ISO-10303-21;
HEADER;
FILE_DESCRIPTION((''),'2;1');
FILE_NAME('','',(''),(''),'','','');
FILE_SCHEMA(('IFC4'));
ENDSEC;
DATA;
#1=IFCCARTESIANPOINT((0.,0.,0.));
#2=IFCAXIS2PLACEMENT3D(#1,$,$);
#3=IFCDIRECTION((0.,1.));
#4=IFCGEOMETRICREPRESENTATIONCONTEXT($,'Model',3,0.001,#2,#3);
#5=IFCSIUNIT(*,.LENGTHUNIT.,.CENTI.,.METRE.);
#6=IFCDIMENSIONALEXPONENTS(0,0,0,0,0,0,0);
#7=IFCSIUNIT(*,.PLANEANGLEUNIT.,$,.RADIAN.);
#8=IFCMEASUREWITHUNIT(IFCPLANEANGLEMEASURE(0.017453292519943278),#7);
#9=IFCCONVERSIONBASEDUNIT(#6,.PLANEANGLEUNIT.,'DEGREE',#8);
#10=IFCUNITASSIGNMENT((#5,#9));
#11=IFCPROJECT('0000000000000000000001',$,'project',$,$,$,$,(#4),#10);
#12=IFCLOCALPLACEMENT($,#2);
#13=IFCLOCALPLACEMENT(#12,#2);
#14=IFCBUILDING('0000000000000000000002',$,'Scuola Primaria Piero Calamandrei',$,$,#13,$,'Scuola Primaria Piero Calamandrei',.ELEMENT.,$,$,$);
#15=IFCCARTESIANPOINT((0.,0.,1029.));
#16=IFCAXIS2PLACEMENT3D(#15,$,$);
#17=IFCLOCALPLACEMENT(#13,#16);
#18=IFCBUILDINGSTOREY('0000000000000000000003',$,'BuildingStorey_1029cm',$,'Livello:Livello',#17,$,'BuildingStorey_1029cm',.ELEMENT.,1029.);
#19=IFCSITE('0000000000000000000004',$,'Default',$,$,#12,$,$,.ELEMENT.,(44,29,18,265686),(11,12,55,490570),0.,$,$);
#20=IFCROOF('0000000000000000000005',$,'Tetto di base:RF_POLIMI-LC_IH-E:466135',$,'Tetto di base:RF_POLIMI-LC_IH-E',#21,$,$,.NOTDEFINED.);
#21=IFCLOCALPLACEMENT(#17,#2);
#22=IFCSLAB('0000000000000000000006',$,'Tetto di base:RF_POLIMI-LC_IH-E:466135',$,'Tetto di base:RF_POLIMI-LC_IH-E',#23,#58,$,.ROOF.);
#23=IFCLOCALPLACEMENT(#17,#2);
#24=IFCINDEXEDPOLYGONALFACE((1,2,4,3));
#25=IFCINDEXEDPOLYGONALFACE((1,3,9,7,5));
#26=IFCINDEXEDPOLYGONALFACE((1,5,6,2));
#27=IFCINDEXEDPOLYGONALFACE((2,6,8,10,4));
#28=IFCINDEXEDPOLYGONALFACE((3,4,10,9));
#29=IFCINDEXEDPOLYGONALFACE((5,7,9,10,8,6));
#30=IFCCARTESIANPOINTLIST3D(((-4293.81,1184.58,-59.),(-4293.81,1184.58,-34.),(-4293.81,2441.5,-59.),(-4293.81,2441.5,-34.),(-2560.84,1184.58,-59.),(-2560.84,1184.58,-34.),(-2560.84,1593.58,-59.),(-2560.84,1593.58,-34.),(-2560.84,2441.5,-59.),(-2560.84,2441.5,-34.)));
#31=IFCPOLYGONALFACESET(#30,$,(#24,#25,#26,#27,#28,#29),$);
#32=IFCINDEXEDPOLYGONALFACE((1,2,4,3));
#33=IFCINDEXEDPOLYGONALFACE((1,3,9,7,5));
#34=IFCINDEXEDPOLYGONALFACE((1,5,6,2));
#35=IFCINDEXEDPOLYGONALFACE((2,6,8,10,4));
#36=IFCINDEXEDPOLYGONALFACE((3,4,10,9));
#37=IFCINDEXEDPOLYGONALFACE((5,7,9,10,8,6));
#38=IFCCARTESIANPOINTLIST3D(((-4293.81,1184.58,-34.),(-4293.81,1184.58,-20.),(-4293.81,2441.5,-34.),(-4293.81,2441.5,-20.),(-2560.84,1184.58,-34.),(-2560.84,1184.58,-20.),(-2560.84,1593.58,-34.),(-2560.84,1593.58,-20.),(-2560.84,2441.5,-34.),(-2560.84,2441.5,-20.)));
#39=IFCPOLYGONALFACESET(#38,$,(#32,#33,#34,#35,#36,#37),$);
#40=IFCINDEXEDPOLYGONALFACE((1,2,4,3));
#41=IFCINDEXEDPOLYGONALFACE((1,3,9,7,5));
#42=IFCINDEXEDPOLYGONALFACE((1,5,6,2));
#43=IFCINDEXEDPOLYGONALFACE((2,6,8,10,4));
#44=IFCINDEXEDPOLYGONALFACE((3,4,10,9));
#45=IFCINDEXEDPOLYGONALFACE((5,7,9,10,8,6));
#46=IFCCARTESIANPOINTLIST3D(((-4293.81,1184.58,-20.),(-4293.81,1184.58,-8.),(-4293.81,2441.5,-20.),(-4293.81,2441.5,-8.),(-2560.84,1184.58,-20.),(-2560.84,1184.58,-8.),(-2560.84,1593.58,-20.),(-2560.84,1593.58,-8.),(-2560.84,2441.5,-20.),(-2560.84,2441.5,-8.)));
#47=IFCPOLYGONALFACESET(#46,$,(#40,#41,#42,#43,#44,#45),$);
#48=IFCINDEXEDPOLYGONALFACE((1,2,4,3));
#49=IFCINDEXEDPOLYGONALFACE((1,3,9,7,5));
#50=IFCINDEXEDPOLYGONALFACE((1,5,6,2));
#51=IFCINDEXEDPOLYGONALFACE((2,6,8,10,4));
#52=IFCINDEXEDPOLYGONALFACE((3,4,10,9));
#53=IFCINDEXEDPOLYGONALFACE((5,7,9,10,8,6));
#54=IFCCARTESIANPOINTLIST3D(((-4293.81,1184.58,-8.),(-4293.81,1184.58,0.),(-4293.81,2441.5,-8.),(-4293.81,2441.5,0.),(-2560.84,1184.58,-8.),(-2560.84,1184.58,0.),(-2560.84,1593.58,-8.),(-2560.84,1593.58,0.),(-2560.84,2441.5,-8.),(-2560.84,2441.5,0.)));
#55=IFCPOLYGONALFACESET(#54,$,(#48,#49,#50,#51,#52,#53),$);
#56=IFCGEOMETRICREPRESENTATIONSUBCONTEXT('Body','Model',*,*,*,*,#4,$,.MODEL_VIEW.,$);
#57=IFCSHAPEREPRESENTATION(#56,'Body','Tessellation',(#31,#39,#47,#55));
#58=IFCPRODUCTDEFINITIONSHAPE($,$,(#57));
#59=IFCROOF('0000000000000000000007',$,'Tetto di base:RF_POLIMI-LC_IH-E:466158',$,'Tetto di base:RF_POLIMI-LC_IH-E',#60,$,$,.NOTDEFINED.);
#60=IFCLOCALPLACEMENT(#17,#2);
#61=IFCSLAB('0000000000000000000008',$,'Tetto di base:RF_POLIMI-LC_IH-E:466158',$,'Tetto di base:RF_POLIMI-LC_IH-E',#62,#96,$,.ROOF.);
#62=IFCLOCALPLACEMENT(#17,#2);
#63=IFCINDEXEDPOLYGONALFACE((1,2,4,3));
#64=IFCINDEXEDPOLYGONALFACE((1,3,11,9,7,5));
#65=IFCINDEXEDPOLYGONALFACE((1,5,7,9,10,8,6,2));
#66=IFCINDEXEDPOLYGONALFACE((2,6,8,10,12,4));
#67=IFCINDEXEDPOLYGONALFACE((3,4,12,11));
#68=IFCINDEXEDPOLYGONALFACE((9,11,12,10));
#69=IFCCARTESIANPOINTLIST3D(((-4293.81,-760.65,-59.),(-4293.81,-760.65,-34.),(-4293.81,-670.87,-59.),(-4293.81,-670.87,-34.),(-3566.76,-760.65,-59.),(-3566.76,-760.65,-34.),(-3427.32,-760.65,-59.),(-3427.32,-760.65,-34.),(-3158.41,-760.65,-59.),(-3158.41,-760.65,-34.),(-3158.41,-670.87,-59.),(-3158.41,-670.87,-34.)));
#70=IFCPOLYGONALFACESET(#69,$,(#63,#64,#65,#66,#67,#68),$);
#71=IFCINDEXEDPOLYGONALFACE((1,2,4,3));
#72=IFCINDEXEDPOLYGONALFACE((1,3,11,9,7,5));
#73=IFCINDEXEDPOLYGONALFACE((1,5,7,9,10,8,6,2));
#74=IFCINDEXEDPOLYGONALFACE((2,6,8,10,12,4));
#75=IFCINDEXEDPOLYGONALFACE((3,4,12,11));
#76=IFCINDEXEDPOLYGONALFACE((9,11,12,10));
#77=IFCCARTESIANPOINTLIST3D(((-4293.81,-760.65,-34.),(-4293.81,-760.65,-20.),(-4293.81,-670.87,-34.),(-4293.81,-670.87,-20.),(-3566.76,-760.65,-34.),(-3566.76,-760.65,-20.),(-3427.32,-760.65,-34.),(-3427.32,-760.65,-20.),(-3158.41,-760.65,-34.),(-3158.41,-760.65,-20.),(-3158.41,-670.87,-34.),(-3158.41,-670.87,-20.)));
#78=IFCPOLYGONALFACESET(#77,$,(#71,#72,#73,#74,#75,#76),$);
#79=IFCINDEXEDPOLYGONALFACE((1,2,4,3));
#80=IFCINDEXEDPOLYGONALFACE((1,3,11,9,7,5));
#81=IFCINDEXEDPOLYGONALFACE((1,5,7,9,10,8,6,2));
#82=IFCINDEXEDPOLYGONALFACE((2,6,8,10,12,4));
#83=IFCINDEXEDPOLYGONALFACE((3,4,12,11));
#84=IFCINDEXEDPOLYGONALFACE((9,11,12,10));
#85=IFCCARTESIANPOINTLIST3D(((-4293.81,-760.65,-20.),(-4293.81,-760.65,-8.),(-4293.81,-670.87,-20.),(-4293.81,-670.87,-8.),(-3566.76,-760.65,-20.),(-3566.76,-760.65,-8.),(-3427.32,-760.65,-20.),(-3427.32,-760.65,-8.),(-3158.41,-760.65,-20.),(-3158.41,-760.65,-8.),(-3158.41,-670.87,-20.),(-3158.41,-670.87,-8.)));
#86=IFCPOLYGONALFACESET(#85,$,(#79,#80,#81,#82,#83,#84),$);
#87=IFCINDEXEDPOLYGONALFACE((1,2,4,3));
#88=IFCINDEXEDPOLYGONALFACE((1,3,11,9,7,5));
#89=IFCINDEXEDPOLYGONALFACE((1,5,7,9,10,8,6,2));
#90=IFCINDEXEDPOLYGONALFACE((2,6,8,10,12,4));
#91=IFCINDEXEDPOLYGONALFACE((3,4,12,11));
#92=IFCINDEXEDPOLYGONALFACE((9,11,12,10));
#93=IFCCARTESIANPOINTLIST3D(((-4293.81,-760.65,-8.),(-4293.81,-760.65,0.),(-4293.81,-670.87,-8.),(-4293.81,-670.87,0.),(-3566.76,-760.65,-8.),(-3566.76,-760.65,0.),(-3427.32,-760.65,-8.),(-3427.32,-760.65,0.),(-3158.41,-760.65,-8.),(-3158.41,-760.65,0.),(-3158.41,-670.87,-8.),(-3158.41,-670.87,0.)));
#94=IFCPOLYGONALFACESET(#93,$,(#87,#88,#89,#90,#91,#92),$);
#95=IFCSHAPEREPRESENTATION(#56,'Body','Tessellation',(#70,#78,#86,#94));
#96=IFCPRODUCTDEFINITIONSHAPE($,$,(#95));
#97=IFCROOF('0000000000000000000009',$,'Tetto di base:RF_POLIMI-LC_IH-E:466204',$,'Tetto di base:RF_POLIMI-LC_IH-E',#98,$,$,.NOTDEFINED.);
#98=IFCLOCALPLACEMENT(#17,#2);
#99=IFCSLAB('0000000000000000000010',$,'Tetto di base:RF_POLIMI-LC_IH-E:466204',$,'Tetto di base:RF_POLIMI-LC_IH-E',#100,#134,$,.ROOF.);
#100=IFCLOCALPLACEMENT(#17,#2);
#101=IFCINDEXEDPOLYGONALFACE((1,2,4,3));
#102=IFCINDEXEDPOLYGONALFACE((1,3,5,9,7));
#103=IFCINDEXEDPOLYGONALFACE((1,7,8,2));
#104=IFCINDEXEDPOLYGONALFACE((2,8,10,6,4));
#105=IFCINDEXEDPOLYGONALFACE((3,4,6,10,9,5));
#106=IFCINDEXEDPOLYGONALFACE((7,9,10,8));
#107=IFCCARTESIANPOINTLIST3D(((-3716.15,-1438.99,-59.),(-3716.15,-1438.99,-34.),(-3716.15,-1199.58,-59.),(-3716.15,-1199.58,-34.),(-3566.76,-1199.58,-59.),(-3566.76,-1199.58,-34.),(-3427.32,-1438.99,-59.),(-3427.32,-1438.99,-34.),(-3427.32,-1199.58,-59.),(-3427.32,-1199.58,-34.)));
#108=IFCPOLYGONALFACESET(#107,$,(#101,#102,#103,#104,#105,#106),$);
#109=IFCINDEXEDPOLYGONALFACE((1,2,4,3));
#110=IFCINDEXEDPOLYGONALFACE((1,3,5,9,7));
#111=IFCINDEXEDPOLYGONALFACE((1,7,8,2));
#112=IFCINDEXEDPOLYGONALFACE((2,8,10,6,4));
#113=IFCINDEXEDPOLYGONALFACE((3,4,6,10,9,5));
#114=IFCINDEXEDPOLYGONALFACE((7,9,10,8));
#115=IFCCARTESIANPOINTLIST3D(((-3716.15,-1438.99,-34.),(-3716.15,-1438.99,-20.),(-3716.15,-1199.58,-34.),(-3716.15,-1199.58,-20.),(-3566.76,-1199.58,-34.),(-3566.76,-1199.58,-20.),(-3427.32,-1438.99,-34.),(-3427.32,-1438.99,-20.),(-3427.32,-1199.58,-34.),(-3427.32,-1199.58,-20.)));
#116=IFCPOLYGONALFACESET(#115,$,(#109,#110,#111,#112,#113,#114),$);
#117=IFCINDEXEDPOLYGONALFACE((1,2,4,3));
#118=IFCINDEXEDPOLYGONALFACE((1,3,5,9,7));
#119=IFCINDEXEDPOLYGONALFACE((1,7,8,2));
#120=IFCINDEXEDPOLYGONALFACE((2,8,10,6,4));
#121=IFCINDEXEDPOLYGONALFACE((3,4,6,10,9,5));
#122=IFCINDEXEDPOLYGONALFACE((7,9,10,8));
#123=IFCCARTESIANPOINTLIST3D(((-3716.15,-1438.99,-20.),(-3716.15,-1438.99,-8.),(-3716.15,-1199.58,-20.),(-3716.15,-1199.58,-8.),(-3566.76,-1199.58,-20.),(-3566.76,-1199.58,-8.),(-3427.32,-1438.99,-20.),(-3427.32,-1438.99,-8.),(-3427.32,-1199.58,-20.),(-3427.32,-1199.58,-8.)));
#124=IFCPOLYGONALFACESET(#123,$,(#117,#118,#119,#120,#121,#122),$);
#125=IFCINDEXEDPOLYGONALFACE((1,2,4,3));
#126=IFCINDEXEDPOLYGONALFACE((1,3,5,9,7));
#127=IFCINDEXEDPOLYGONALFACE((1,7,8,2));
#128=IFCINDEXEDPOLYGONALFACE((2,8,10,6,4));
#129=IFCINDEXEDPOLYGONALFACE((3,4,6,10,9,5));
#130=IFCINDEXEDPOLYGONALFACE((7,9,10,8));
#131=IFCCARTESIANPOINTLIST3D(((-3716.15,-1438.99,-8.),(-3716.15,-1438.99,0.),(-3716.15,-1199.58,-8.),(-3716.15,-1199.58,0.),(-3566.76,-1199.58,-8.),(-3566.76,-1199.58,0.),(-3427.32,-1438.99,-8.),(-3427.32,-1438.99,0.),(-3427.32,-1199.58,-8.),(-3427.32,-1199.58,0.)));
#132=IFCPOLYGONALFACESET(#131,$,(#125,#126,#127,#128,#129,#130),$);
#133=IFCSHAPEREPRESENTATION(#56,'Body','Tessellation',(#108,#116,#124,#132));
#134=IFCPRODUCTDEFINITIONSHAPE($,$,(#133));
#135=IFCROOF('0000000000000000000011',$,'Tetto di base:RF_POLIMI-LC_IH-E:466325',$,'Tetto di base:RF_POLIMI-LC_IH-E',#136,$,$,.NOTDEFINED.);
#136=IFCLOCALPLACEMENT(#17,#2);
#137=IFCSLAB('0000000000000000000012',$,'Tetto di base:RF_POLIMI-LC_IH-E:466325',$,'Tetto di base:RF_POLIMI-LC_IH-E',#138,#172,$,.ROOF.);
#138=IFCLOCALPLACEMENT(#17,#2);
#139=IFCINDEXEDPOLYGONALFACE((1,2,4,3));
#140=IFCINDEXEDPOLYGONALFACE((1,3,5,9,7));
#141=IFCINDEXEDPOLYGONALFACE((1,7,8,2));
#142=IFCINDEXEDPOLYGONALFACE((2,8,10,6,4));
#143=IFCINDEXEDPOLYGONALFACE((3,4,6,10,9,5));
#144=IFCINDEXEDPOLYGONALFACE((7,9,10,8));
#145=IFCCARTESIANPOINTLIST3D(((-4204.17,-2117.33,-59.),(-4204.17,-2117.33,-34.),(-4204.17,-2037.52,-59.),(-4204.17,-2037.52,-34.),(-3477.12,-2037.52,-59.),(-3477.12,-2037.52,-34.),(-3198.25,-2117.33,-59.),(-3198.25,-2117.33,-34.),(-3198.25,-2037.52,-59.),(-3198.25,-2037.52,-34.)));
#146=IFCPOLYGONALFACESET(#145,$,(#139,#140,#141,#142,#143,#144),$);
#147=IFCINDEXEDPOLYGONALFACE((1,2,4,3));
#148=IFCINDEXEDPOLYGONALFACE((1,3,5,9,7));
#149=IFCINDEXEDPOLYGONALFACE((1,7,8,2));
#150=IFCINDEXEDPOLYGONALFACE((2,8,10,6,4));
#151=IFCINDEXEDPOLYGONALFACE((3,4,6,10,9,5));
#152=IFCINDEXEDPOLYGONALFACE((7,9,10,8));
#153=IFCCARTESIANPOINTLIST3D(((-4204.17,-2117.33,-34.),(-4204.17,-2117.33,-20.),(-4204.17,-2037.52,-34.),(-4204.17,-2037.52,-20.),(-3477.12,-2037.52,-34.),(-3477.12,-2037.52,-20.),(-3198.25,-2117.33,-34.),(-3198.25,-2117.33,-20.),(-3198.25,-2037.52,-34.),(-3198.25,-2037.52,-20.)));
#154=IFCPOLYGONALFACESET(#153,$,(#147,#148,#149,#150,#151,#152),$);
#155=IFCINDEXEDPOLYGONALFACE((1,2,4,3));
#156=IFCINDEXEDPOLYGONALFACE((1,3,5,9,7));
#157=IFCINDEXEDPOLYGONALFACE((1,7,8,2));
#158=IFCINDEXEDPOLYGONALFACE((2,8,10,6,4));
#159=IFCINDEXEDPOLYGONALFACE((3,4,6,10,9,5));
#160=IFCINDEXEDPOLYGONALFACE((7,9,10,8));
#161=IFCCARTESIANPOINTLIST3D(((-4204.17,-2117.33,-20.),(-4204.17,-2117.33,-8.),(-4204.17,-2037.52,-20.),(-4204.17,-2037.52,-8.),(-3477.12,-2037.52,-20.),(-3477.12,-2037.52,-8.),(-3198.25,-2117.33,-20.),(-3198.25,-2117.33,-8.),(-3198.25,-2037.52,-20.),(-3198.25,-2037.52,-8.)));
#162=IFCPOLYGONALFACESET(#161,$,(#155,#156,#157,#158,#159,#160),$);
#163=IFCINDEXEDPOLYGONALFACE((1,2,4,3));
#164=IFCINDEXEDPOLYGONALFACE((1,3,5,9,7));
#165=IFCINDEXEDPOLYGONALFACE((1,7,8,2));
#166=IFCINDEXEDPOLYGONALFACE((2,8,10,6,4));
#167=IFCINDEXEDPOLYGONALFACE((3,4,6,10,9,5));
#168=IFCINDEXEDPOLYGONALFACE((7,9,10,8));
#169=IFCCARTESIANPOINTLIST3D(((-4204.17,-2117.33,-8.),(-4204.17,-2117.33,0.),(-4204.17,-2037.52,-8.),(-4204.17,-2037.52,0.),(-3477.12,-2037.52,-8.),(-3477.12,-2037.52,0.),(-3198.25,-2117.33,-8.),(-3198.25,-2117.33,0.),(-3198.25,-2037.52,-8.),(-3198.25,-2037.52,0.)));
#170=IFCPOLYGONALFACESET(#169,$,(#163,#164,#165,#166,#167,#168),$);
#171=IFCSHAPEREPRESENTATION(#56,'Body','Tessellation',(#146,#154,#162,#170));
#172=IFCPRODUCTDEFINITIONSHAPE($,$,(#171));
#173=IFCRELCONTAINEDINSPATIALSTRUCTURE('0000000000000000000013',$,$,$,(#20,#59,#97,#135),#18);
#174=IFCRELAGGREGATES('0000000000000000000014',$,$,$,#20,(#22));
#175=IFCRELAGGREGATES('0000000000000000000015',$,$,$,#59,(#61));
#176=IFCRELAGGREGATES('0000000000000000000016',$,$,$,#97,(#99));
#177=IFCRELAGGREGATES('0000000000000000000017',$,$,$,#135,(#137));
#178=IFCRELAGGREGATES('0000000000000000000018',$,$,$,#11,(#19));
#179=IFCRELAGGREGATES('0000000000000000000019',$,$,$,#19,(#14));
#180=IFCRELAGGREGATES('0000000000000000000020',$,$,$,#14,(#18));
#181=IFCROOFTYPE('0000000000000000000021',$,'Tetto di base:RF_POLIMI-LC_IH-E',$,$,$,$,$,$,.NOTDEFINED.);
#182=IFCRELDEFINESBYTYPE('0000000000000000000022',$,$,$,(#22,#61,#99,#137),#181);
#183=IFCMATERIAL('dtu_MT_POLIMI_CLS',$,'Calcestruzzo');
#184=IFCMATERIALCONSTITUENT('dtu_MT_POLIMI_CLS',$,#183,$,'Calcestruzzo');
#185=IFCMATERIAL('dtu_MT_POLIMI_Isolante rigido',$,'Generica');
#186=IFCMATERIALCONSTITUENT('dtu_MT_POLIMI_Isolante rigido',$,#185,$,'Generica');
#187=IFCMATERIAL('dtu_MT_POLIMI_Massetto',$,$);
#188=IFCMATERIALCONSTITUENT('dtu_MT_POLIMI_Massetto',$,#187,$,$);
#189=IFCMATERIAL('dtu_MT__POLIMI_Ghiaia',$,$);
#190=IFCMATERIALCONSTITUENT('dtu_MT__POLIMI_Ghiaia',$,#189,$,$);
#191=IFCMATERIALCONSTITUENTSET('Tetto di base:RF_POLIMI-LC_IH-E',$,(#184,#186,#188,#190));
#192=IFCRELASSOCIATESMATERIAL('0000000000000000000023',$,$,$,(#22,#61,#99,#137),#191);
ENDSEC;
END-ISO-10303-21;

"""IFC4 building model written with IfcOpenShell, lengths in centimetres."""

from ifc_helpers import new_model, entity, si_unit, converted_unit, direction, frame, origin, place, context, subcontext, project, spatial, indexed_curve, outline, extrude, material, constituent, constituent_set, type_object, element, aggregate, save


model = new_model("IFC4")

# Units and contexts
model_context = context("Model", 3, precision=0.001, world=origin(), true_north=direction((0.0, 1.0)))
body_context = subcontext(model_context, "Body", "Model", "MODEL_VIEW")
ifc_project = project(units=[si_unit("LENGTHUNIT", "METRE", prefix="CENTI"), converted_unit("PLANEANGLEUNIT", "DEGREE", entity("IfcPlaneAngleMeasure", 0.017453292519943278), si_unit("PLANEANGLEUNIT", "RADIAN"), dimensions=[0, 0, 0, 0, 0, 0, 0])], contexts=[model_context])

# Site, building, storey
site_placement = place(None, origin())
site = spatial("IfcSite", under=ifc_project, at=site_placement, Name="Default", CompositionType="ELEMENT", RefLatitude=(44, 29, 18, 265686), RefLongitude=(11, 12, 55, 490570), RefElevation=0.0)
building_placement = place(site_placement, origin())
building = spatial("IfcBuilding", under=site, at=building_placement, Name="Scuola Primaria Piero Calamandrei", LongName="Scuola Primaria Piero Calamandrei", CompositionType="ELEMENT")
storey_placement = place(building_placement, frame((0.0, 0.0, 1029.0)))
storey = spatial("IfcBuildingStorey", under=building, at=storey_placement, Name="BuildingStorey_1029cm", ObjectType="Livello:Livello", LongName="BuildingStorey_1029cm", CompositionType="ELEMENT", Elevation=1029.0)

# Shared definitions
ifc_material_1 = material(Name="dtu_MT_POLIMI_Isolante rigido", Category="Generica")

# Roofs, slabs
ifc_material_2 = material(Name="dtu_MT_POLIMI_CLS", Category="Calcestruzzo")
ifc_constituent_1 = constituent(ifc_material_2, Name="dtu_MT_POLIMI_CLS", Category="Calcestruzzo")
ifc_constituent_2 = constituent(ifc_material_1, Name="dtu_MT_POLIMI_Isolante rigido", Category="Generica")
ifc_material_3 = material(Name="dtu_MT_POLIMI_Massetto")
ifc_constituent_3 = constituent(ifc_material_3, Name="dtu_MT_POLIMI_Massetto")
ifc_material_4 = material(Name="dtu_MT__POLIMI_Ghiaia")
ifc_constituent_4 = constituent(ifc_material_4, Name="dtu_MT__POLIMI_Ghiaia")
ifc_constituent_set_1 = constituent_set(constituents=[ifc_constituent_1, ifc_constituent_2, ifc_constituent_3, ifc_constituent_4], Name="Tetto di base:RF_POLIMI-LC_IH-E")
roof_type = type_object("IfcRoofType", Name="Tetto di base:RF_POLIMI-LC_IH-E", PredefinedType="NOTDEFINED")
roof_1_placement = place(storey_placement, frame((-4293.81, 1184.58, -59.0)))
roof_1 = element("IfcRoof", 1, at=roof_1_placement, inside=storey, Name="Tetto di base:RF_POLIMI-LC_IH-E:466135", ObjectType="Tetto di base:RF_POLIMI-LC_IH-E", PredefinedType="NOTDEFINED")
slab_1_placement = place(roof_1_placement, origin())
slab_1 = element("IfcSlab", 2, at=slab_1_placement, type_object=roof_type, material=ifc_constituent_set_1, Name="Tetto di base:RF_POLIMI-LC_IH-E:466135", ObjectType="Tetto di base:RF_POLIMI-LC_IH-E", PredefinedType="ROOF", context=body_context, shape_type="SweptSolid", body=[
    extrude(outline(indexed_curve([(866.49, -628.46), (866.49, -219.46), (866.49, 628.46), (-866.49, 628.46), (-866.49, -628.46), (866.49, -628.46)], self_intersect=False)), frame((866.49, 628.46, 0.0)), (0.0, 0.0, 1.0), 25.0),
    extrude(outline(indexed_curve([(866.49, -628.46), (866.49, -219.46), (866.49, 628.46), (-866.49, 628.46), (-866.49, -628.46), (866.49, -628.46)], self_intersect=False)), frame((866.49, 628.46, 25.0)), (0.0, 0.0, 1.0), 14.0),
    extrude(outline(indexed_curve([(866.49, -628.46), (866.49, -219.46), (866.49, 628.46), (-866.49, 628.46), (-866.49, -628.46), (866.49, -628.46)], self_intersect=False)), frame((866.49, 628.46, 39.0)), (0.0, 0.0, 1.0), 12.0),
    extrude(outline(indexed_curve([(866.49, -628.46), (866.49, -219.46), (866.49, 628.46), (-866.49, 628.46), (-866.49, -628.46), (866.49, -628.46)], self_intersect=False)), frame((866.49, 628.46, 51.0)), (0.0, 0.0, 1.0), 8.0),
])
aggregate(roof_1, [slab_1])
roof_2_placement = place(storey_placement, frame((-4293.81, -760.65, -59.0)))
roof_2 = element("IfcRoof", 3, at=roof_2_placement, inside=storey, Name="Tetto di base:RF_POLIMI-LC_IH-E:466158", ObjectType="Tetto di base:RF_POLIMI-LC_IH-E", PredefinedType="NOTDEFINED")
slab_2_placement = place(roof_2_placement, origin())
slab_2 = element("IfcSlab", 4, at=slab_2_placement, type_object=roof_type, material=ifc_constituent_set_1, Name="Tetto di base:RF_POLIMI-LC_IH-E:466158", ObjectType="Tetto di base:RF_POLIMI-LC_IH-E", PredefinedType="ROOF", context=body_context, shape_type="SweptSolid", body=[
    extrude(outline(indexed_curve([(-567.7, 44.89), (-567.7, -44.89), (159.35, -44.89), (298.79, -44.89), (567.7, -44.89), (567.7, 44.89), (-567.7, 44.89)], self_intersect=False)), frame((567.7, 44.89, 0.0)), (0.0, 0.0, 1.0), 25.0),
    extrude(outline(indexed_curve([(-567.7, 44.89), (-567.7, -44.89), (159.35, -44.89), (298.79, -44.89), (567.7, -44.89), (567.7, 44.89), (-567.7, 44.89)], self_intersect=False)), frame((567.7, 44.89, 25.0)), (0.0, 0.0, 1.0), 14.0),
    extrude(outline(indexed_curve([(-567.7, 44.89), (-567.7, -44.89), (159.35, -44.89), (298.79, -44.89), (567.7, -44.89), (567.7, 44.89), (-567.7, 44.89)], self_intersect=False)), frame((567.7, 44.89, 39.0)), (0.0, 0.0, 1.0), 12.0),
    extrude(outline(indexed_curve([(-567.7, 44.89), (-567.7, -44.89), (159.35, -44.89), (298.79, -44.89), (567.7, -44.89), (567.7, 44.89), (-567.7, 44.89)], self_intersect=False)), frame((567.7, 44.89, 51.0)), (0.0, 0.0, 1.0), 8.0),
])
aggregate(roof_2, [slab_2])
roof_3_placement = place(storey_placement, frame((-3716.15, -1438.99, -59.0)))
roof_3 = element("IfcRoof", 5, at=roof_3_placement, inside=storey, Name="Tetto di base:RF_POLIMI-LC_IH-E:466204", ObjectType="Tetto di base:RF_POLIMI-LC_IH-E", PredefinedType="NOTDEFINED")
slab_3_placement = place(roof_3_placement, origin())
slab_3 = element("IfcSlab", 6, at=slab_3_placement, type_object=roof_type, material=ifc_constituent_set_1, Name="Tetto di base:RF_POLIMI-LC_IH-E:466204", ObjectType="Tetto di base:RF_POLIMI-LC_IH-E", PredefinedType="ROOF", context=body_context, shape_type="SweptSolid", body=[
    extrude(outline(indexed_curve([(-144.41, -119.71), (144.41, -119.71), (144.41, 119.71), (4.98, 119.71), (-144.41, 119.71), (-144.41, -119.71)], self_intersect=False)), frame((144.41, 119.71, 0.0)), (0.0, 0.0, 1.0), 25.0),
    extrude(outline(indexed_curve([(-144.41, -119.71), (144.41, -119.71), (144.41, 119.71), (4.98, 119.71), (-144.41, 119.71), (-144.41, -119.71)], self_intersect=False)), frame((144.41, 119.71, 25.0)), (0.0, 0.0, 1.0), 14.0),
    extrude(outline(indexed_curve([(-144.41, -119.71), (144.41, -119.71), (144.41, 119.71), (4.98, 119.71), (-144.41, 119.71), (-144.41, -119.71)], self_intersect=False)), frame((144.41, 119.71, 39.0)), (0.0, 0.0, 1.0), 12.0),
    extrude(outline(indexed_curve([(-144.41, -119.71), (144.41, -119.71), (144.41, 119.71), (4.98, 119.71), (-144.41, 119.71), (-144.41, -119.71)], self_intersect=False)), frame((144.41, 119.71, 51.0)), (0.0, 0.0, 1.0), 8.0),
])
aggregate(roof_3, [slab_3])
roof_4_placement = place(storey_placement, frame((-4204.17, -2117.33, -59.0)))
roof_4 = element("IfcRoof", 7, at=roof_4_placement, inside=storey, Name="Tetto di base:RF_POLIMI-LC_IH-E:466325", ObjectType="Tetto di base:RF_POLIMI-LC_IH-E", PredefinedType="NOTDEFINED")
slab_4_placement = place(roof_4_placement, origin())
slab_4 = element("IfcSlab", 8, at=slab_4_placement, type_object=roof_type, material=ifc_constituent_set_1, Name="Tetto di base:RF_POLIMI-LC_IH-E:466325", ObjectType="Tetto di base:RF_POLIMI-LC_IH-E", PredefinedType="ROOF", context=body_context, shape_type="SweptSolid", body=[
    extrude(outline(indexed_curve([(224.09, 39.9), (-502.96, 39.9), (-502.96, -39.9), (502.96, -39.9), (502.96, 39.9), (224.09, 39.9)], self_intersect=False)), frame((502.96, 39.9, 0.0)), (0.0, 0.0, 1.0), 25.0),
    extrude(outline(indexed_curve([(224.09, 39.9), (-502.96, 39.9), (-502.96, -39.9), (502.96, -39.9), (502.96, 39.9), (224.09, 39.9)], self_intersect=False)), frame((502.96, 39.9, 25.0)), (0.0, 0.0, 1.0), 14.0),
    extrude(outline(indexed_curve([(224.09, 39.9), (-502.96, 39.9), (-502.96, -39.9), (502.96, -39.9), (502.96, 39.9), (224.09, 39.9)], self_intersect=False)), frame((502.96, 39.9, 39.0)), (0.0, 0.0, 1.0), 12.0),
    extrude(outline(indexed_curve([(224.09, 39.9), (-502.96, 39.9), (-502.96, -39.9), (502.96, -39.9), (502.96, 39.9), (224.09, 39.9)], self_intersect=False)), frame((502.96, 39.9, 51.0)), (0.0, 0.0, 1.0), 8.0),
])
aggregate(roof_4, [slab_4])

save(model, "model.ifc")
